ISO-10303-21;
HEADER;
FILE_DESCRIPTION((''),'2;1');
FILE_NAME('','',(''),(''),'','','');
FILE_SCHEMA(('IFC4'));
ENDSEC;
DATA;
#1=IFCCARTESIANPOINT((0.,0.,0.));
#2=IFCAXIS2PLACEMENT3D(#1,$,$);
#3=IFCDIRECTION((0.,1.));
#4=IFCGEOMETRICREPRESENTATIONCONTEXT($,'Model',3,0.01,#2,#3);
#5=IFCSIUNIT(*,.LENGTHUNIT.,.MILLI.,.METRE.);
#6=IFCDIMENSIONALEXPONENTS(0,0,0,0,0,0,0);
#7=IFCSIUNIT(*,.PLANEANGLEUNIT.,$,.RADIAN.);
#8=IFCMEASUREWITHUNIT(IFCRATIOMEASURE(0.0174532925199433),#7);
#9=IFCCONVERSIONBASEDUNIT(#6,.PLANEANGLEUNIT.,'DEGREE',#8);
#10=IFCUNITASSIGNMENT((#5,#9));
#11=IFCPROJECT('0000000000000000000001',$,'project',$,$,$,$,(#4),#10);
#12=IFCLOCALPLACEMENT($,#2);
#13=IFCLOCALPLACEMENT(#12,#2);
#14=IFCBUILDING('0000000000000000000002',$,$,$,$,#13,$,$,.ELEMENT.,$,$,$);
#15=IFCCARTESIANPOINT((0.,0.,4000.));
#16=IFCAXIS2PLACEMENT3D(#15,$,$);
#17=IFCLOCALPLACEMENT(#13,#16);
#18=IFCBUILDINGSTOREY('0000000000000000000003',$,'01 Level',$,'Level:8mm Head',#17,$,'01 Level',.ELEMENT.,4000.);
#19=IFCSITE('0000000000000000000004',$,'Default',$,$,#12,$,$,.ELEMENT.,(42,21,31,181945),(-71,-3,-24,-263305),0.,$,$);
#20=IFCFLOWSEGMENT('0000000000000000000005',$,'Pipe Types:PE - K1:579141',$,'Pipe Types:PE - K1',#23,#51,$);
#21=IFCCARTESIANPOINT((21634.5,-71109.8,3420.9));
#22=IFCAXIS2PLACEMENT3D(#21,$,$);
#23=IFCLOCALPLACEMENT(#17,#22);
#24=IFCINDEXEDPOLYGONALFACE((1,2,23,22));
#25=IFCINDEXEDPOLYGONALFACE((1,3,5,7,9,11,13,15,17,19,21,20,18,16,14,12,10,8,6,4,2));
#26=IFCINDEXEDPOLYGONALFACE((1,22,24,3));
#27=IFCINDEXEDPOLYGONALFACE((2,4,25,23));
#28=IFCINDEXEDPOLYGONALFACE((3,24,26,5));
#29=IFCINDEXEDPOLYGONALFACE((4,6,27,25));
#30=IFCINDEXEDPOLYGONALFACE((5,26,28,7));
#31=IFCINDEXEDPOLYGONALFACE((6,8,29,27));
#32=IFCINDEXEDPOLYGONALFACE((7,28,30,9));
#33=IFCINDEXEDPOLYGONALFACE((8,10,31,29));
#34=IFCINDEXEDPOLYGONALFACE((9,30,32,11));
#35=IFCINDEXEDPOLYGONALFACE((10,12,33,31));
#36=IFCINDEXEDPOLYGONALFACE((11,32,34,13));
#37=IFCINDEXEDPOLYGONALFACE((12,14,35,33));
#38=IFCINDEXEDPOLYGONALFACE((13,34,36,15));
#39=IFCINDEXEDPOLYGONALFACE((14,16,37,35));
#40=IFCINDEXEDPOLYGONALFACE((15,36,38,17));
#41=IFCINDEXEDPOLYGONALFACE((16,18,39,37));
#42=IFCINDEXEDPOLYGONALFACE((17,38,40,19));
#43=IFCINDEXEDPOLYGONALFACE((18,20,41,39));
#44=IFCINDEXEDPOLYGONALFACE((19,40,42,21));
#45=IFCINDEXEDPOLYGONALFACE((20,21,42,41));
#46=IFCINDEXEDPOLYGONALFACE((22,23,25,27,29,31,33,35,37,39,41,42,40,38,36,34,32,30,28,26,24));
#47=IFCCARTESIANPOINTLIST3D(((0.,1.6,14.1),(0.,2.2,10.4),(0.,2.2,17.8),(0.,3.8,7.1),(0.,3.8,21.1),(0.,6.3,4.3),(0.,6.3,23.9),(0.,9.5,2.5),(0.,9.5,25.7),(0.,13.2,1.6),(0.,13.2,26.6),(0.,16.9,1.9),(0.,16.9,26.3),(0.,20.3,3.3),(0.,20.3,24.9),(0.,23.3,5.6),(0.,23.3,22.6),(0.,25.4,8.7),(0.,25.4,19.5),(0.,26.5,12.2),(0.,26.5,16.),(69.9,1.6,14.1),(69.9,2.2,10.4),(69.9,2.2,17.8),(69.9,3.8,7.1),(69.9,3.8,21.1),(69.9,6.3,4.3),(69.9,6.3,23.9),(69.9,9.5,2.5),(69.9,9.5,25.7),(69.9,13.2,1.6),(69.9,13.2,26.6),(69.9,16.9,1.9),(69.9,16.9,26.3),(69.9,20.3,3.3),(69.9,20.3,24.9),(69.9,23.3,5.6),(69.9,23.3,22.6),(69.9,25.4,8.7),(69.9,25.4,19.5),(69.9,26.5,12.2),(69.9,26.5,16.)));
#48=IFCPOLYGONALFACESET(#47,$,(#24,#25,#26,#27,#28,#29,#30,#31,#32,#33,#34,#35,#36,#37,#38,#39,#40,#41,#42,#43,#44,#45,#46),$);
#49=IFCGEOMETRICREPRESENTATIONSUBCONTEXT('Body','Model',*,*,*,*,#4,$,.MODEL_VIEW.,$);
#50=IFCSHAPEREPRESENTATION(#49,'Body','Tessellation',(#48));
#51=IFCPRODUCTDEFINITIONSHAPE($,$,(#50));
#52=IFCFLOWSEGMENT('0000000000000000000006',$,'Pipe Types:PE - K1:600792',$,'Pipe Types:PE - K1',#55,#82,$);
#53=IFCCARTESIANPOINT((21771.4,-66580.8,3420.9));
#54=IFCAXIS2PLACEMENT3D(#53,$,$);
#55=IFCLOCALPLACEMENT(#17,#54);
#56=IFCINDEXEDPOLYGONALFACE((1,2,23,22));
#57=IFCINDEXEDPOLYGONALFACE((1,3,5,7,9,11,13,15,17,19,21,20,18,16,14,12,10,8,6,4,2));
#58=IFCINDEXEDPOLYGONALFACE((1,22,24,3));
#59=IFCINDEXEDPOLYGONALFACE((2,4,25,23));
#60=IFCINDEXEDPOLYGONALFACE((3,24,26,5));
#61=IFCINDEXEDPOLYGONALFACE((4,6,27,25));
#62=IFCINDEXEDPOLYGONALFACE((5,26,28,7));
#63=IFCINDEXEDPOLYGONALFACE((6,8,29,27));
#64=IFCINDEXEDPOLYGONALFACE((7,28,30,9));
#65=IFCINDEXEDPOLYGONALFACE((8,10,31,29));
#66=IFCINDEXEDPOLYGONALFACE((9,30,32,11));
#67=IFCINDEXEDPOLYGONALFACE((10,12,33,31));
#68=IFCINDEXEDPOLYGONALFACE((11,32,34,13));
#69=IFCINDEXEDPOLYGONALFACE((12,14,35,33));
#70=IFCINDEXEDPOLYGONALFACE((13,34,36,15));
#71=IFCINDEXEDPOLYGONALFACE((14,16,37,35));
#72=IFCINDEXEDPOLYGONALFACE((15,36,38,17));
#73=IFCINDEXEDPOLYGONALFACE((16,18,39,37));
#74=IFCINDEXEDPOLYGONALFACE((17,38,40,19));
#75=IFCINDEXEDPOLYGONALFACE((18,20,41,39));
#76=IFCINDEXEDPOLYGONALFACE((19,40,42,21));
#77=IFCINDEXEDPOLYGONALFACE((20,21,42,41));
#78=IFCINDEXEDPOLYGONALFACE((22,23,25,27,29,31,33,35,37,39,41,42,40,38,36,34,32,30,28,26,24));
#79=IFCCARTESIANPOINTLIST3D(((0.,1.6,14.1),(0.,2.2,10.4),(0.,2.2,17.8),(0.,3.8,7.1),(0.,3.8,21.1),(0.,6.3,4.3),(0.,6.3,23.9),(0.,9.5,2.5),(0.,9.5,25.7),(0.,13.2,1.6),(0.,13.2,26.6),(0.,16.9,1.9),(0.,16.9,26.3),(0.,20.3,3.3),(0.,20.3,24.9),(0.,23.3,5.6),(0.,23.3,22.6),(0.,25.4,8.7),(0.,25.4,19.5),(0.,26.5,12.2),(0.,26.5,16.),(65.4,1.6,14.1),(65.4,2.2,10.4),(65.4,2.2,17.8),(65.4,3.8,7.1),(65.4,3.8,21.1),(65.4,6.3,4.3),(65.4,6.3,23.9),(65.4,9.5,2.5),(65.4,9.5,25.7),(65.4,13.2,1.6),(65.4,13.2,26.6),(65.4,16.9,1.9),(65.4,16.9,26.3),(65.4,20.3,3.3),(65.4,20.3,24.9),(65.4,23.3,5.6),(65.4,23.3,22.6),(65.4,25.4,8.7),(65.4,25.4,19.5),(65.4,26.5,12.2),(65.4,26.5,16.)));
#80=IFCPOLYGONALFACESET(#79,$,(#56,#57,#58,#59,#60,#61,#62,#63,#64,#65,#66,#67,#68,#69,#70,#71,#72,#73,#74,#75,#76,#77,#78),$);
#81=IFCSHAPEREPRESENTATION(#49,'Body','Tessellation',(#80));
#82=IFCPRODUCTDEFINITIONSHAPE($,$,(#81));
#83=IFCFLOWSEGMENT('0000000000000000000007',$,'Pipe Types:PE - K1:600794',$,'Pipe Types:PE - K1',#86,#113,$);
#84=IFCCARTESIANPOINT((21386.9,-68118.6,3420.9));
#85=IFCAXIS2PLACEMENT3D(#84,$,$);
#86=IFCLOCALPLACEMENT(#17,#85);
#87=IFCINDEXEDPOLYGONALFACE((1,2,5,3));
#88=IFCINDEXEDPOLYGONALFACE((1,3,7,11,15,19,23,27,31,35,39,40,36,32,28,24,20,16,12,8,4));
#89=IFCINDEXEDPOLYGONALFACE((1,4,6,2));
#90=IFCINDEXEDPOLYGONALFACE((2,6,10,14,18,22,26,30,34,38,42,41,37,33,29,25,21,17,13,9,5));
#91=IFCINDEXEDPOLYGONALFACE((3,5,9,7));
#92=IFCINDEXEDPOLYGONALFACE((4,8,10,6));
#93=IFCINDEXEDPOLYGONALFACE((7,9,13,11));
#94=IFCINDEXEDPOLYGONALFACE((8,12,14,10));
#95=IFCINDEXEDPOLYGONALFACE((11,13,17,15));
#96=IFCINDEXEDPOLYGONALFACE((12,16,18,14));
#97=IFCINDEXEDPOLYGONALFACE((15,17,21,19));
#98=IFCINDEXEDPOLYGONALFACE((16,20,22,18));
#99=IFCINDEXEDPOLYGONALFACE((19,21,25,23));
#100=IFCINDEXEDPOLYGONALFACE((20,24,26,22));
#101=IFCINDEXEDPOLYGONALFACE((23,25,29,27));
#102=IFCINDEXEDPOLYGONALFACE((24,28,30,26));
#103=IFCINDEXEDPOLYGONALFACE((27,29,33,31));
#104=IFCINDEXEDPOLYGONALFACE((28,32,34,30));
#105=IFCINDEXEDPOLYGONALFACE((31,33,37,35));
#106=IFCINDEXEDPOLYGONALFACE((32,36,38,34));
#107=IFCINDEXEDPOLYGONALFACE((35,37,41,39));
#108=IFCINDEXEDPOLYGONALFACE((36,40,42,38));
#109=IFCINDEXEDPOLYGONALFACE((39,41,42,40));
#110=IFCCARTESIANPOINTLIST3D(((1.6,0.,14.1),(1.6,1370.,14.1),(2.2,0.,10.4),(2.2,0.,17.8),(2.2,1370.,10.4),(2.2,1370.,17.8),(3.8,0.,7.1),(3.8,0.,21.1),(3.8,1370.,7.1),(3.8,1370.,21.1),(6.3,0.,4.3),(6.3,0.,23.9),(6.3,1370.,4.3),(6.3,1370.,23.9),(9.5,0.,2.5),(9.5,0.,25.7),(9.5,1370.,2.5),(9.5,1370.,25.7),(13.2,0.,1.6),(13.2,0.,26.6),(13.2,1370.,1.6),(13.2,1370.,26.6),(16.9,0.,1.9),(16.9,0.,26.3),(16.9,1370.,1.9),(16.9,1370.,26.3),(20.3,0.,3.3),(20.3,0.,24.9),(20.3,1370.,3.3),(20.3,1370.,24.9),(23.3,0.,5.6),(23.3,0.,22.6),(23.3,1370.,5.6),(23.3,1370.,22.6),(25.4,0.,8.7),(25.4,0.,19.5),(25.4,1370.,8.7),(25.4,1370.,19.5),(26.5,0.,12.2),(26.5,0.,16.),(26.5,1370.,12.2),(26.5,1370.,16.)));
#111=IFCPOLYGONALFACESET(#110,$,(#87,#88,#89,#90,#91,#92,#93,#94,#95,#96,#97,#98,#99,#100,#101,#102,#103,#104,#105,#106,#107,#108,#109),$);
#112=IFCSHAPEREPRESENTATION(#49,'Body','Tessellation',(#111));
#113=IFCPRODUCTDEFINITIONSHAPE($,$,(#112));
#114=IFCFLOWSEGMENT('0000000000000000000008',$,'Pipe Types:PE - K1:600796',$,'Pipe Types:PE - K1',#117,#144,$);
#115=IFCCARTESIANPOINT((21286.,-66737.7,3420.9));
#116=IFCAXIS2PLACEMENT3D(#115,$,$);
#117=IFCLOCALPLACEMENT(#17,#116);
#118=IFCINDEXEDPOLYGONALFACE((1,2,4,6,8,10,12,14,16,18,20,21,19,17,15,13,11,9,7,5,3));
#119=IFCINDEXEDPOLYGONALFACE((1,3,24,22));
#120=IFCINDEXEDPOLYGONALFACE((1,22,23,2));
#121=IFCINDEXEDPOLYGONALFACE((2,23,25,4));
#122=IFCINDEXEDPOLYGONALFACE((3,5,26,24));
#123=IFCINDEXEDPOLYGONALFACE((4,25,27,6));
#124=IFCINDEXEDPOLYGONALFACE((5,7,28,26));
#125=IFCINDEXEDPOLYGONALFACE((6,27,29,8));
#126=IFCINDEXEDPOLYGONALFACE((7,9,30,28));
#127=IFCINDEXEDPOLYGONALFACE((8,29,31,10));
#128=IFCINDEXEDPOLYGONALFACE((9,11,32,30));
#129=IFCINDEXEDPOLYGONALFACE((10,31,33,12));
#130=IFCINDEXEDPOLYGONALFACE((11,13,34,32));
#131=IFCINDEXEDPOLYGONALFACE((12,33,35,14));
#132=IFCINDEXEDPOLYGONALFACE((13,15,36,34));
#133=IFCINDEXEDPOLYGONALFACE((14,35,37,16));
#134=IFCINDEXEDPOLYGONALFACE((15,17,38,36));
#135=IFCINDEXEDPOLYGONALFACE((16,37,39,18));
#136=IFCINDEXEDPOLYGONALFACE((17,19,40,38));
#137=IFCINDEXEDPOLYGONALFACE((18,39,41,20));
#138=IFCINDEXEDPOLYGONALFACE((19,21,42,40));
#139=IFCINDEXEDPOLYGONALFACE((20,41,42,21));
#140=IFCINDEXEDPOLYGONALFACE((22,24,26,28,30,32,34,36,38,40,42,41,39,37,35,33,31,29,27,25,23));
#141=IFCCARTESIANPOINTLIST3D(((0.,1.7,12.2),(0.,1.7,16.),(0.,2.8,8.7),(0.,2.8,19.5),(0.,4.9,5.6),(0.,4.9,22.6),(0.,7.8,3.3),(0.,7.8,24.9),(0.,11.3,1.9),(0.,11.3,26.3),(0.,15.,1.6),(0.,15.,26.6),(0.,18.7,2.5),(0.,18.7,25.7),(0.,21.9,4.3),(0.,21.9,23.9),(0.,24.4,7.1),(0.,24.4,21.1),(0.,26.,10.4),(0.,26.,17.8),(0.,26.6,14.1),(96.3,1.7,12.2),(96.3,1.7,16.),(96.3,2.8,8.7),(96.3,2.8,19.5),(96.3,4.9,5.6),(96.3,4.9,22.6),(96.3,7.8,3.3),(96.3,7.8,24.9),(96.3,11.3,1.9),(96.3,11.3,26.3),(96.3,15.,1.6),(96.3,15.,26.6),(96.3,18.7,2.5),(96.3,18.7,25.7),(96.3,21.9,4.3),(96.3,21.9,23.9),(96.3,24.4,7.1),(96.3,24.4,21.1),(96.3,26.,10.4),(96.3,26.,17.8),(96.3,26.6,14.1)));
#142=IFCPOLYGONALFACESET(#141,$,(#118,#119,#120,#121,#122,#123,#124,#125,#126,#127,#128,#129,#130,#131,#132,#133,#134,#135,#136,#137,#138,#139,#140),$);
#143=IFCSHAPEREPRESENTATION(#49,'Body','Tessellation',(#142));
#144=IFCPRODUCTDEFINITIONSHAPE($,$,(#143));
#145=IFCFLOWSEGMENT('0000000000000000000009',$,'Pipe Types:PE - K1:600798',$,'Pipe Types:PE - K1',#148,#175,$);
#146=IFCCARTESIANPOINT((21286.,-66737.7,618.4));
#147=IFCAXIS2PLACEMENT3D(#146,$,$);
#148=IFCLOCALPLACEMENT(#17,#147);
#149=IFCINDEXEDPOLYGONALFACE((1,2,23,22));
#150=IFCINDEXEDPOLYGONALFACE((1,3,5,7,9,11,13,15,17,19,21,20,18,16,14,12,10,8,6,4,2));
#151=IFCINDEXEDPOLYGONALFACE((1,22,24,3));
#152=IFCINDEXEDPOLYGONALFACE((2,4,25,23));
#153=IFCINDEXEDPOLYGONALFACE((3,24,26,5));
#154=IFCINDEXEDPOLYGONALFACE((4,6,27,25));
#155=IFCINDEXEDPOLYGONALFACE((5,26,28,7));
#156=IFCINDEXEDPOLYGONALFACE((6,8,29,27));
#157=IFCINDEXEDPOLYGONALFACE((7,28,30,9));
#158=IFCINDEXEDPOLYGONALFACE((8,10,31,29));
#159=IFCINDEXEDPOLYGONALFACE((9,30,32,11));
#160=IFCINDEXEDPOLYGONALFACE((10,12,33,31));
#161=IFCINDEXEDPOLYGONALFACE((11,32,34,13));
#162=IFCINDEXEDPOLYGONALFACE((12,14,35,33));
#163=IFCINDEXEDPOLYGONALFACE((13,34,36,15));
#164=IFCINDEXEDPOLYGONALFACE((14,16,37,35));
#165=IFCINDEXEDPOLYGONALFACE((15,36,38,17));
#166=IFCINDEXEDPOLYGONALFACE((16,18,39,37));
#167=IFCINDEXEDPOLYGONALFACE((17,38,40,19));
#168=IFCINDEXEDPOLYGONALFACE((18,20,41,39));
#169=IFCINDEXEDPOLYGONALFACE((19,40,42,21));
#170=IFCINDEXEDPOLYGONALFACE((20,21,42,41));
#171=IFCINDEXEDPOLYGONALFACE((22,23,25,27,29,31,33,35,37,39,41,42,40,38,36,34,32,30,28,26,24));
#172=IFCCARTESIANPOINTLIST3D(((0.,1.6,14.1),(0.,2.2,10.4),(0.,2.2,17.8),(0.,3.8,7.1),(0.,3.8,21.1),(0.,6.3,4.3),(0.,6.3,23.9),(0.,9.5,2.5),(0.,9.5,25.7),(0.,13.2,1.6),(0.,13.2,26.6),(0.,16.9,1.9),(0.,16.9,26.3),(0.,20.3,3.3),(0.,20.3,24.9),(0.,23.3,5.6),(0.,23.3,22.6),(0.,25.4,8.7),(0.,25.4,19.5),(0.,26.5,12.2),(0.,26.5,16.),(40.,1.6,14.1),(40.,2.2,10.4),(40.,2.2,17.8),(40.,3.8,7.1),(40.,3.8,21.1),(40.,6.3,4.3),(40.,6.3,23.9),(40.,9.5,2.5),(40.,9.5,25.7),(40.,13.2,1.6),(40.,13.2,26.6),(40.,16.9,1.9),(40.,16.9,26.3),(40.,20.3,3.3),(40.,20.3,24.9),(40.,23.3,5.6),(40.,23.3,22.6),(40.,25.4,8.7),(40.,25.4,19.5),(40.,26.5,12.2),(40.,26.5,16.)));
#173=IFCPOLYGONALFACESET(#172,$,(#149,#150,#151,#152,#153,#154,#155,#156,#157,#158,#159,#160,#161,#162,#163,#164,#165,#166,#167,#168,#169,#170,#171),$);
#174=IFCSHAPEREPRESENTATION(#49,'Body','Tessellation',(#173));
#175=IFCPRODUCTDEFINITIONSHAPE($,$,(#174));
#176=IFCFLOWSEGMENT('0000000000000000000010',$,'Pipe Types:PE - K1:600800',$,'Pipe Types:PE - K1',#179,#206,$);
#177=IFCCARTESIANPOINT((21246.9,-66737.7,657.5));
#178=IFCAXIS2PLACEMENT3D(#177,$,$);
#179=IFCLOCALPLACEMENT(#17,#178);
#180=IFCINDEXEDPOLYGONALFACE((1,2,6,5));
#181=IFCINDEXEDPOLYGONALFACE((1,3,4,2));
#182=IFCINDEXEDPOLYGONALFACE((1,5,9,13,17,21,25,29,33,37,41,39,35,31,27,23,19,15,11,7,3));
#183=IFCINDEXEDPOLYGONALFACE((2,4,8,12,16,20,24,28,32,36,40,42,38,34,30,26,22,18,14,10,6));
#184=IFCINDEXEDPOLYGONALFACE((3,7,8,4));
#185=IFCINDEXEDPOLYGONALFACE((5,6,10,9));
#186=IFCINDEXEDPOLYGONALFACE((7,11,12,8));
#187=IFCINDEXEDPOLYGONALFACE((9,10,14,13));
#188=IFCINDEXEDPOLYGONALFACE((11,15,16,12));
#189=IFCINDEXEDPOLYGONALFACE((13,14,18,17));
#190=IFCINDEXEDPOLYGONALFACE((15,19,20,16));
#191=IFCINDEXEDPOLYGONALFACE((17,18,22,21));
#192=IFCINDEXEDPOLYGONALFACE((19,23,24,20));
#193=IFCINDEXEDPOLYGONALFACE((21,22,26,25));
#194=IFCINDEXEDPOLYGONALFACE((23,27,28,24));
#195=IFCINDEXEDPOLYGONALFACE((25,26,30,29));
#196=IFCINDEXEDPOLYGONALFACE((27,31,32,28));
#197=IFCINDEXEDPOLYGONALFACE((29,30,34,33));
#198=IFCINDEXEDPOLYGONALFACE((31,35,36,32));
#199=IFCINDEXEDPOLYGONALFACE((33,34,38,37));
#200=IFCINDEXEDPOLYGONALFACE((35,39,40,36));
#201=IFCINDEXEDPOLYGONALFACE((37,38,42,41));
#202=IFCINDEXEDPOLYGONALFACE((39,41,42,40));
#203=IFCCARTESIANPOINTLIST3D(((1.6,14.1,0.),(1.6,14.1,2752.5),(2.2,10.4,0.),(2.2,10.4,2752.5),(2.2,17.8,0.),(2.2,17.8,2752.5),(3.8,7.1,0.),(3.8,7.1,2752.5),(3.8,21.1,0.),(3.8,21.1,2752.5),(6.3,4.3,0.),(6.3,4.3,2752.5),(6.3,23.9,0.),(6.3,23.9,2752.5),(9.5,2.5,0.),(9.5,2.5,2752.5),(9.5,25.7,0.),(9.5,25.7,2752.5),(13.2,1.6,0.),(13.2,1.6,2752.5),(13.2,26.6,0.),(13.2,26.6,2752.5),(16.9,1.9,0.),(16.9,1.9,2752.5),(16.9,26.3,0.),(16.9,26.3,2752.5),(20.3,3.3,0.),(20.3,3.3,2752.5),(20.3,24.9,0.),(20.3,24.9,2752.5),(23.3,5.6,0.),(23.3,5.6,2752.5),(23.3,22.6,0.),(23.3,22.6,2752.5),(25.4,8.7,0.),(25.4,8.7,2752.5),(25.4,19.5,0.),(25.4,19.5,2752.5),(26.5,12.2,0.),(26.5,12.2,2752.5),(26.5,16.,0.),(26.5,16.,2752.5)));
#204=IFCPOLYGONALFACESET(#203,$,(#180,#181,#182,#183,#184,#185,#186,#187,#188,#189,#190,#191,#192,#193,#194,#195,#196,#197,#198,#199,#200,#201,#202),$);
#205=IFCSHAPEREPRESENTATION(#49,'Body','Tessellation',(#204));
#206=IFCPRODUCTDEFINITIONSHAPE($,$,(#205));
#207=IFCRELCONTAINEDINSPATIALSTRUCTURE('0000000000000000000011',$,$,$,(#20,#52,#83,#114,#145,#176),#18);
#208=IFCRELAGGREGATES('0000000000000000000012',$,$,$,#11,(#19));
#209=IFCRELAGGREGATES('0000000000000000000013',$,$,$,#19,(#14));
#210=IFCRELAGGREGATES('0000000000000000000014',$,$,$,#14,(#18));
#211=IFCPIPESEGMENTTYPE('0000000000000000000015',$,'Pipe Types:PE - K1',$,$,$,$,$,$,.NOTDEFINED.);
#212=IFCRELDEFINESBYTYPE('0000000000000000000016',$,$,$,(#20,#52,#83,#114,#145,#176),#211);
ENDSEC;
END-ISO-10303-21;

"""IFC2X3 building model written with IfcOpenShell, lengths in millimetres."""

from ifc_helpers import new_model, entity, si_unit, converted_unit, direction, frame, frame_2d, origin, origin_2d_with_axis, place, context, subcontext, project, spatial, circle, extrude, type_object, element, save


model = new_model("IFC2X3")

# Units and contexts
model_context = context("Model", 3, precision=0.01, world=origin(), true_north=direction((0.0, 1.0)))
body_context = subcontext(model_context, "Body", "Model", "MODEL_VIEW")
ifc_project = project(units=[si_unit("LENGTHUNIT", "METRE", prefix="MILLI"), converted_unit("PLANEANGLEUNIT", "DEGREE", entity("IfcRatioMeasure", 0.0174532925199433), si_unit("PLANEANGLEUNIT", "RADIAN"), dimensions=[0, 0, 0, 0, 0, 0, 0])], contexts=[model_context])

# Site, building, storey
site_placement = place(None, origin())
site = spatial("IfcSite", under=ifc_project, at=site_placement, Name="Default", CompositionType="ELEMENT", RefLatitude=(42, 21, 31, 181945), RefLongitude=(-71, -3, -24, -263305), RefElevation=0.0)
building_placement = place(site_placement, origin())
building = spatial("IfcBuilding", under=site, at=building_placement, CompositionType="ELEMENT")
storey_placement = place(building_placement, frame((0.0, 0.0, 4000.0)))
storey = spatial("IfcBuildingStorey", under=building, at=storey_placement, Name="01 Level", ObjectType="Level:8mm Head", LongName="01 Level", CompositionType="ELEMENT", Elevation=4000.0)

# Flow segments
pipe_segment_type = type_object("IfcPipeSegmentType", Name="Pipe Types:PE - K1", PredefinedType="NOTDEFINED")
flow_segment_1_placement = place(storey_placement, frame((21634.5, -71109.8, 3420.9)))
element("IfcFlowSegment", 1, at=flow_segment_1_placement, inside=storey, type_object=pipe_segment_type, Name="Pipe Types:PE - K1:579141", ObjectType="Pipe Types:PE - K1", context=body_context, shape_type="SweptSolid", body=[
    extrude(circle(Radius=12.5, at=frame_2d((0.0, 0.0), x_axis=(1.0, 0.0))), frame((0.0, 14.1, 14.1), z_axis=(1.0, 0.0, 0.0), x_axis=(0.0, -1.0, 0.0)), (0.0, 0.0, 1.0), 69.9),
])
flow_segment_2_placement = place(storey_placement, frame((21771.4, -66580.8, 3420.9)))
element("IfcFlowSegment", 2, at=flow_segment_2_placement, inside=storey, type_object=pipe_segment_type, Name="Pipe Types:PE - K1:600792", ObjectType="Pipe Types:PE - K1", context=body_context, shape_type="SweptSolid", body=[
    extrude(circle(Radius=12.5, at=origin_2d_with_axis()), frame((0.0, 14.1, 14.1), z_axis=(1.0, 0.0, 0.0), x_axis=(0.0, -1.0, 0.0)), (0.0, 0.0, 1.0), 65.4),
])
flow_segment_3_placement = place(storey_placement, frame((21386.9, -68118.6, 3420.9)))
element("IfcFlowSegment", 3, at=flow_segment_3_placement, inside=storey, type_object=pipe_segment_type, Name="Pipe Types:PE - K1:600794", ObjectType="Pipe Types:PE - K1", context=body_context, shape_type="SweptSolid", body=[
    extrude(circle(Radius=12.5, at=frame_2d((0.0, 0.0), x_axis=(1.0, 0.0))), frame((14.1, 0.0, 14.1), z_axis=(0.0, 1.0, 0.0), x_axis=(-1.0, 0.0, 0.0)), (0.0, 0.0, 1.0), 1370.0),
])
flow_segment_4_placement = place(storey_placement, frame((21286.0, -66737.7, 3420.9)))
element("IfcFlowSegment", 4, at=flow_segment_4_placement, inside=storey, type_object=pipe_segment_type, Name="Pipe Types:PE - K1:600796", ObjectType="Pipe Types:PE - K1", context=body_context, shape_type="SweptSolid", body=[
    extrude(circle(Radius=12.5, at=origin_2d_with_axis()), frame((0.0, 14.1, 14.1), z_axis=(1.0, 0.0, 0.0), x_axis=(0.0, 1.0, 0.0)), (0.0, 0.0, 1.0), 96.3),
])
flow_segment_5_placement = place(storey_placement, frame((21286.0, -66737.7, 618.4)))
element("IfcFlowSegment", 5, at=flow_segment_5_placement, inside=storey, type_object=pipe_segment_type, Name="Pipe Types:PE - K1:600798", ObjectType="Pipe Types:PE - K1", context=body_context, shape_type="SweptSolid", body=[
    extrude(circle(Radius=12.5, at=origin_2d_with_axis()), frame((0.0, 14.1, 14.1), z_axis=(1.0, 0.0, 0.0), x_axis=(0.0, -1.0, 0.0)), (0.0, 0.0, 1.0), 40.0),
])
flow_segment_6_placement = place(storey_placement, frame((21246.9, -66737.7, 657.5)))
element("IfcFlowSegment", 6, at=flow_segment_6_placement, inside=storey, type_object=pipe_segment_type, Name="Pipe Types:PE - K1:600800", ObjectType="Pipe Types:PE - K1", context=body_context, shape_type="SweptSolid", body=[
    extrude(circle(Radius=12.5, at=frame_2d((0.0, 0.0), x_axis=(1.0, 0.0))), frame((14.1, 14.1, 0.0), z_axis=(0.0, 0.0, 1.0), x_axis=(-1.0, 0.0, 0.0)), (0.0, 0.0, 1.0), 2752.5),
])

save(model, "model.ifc")
